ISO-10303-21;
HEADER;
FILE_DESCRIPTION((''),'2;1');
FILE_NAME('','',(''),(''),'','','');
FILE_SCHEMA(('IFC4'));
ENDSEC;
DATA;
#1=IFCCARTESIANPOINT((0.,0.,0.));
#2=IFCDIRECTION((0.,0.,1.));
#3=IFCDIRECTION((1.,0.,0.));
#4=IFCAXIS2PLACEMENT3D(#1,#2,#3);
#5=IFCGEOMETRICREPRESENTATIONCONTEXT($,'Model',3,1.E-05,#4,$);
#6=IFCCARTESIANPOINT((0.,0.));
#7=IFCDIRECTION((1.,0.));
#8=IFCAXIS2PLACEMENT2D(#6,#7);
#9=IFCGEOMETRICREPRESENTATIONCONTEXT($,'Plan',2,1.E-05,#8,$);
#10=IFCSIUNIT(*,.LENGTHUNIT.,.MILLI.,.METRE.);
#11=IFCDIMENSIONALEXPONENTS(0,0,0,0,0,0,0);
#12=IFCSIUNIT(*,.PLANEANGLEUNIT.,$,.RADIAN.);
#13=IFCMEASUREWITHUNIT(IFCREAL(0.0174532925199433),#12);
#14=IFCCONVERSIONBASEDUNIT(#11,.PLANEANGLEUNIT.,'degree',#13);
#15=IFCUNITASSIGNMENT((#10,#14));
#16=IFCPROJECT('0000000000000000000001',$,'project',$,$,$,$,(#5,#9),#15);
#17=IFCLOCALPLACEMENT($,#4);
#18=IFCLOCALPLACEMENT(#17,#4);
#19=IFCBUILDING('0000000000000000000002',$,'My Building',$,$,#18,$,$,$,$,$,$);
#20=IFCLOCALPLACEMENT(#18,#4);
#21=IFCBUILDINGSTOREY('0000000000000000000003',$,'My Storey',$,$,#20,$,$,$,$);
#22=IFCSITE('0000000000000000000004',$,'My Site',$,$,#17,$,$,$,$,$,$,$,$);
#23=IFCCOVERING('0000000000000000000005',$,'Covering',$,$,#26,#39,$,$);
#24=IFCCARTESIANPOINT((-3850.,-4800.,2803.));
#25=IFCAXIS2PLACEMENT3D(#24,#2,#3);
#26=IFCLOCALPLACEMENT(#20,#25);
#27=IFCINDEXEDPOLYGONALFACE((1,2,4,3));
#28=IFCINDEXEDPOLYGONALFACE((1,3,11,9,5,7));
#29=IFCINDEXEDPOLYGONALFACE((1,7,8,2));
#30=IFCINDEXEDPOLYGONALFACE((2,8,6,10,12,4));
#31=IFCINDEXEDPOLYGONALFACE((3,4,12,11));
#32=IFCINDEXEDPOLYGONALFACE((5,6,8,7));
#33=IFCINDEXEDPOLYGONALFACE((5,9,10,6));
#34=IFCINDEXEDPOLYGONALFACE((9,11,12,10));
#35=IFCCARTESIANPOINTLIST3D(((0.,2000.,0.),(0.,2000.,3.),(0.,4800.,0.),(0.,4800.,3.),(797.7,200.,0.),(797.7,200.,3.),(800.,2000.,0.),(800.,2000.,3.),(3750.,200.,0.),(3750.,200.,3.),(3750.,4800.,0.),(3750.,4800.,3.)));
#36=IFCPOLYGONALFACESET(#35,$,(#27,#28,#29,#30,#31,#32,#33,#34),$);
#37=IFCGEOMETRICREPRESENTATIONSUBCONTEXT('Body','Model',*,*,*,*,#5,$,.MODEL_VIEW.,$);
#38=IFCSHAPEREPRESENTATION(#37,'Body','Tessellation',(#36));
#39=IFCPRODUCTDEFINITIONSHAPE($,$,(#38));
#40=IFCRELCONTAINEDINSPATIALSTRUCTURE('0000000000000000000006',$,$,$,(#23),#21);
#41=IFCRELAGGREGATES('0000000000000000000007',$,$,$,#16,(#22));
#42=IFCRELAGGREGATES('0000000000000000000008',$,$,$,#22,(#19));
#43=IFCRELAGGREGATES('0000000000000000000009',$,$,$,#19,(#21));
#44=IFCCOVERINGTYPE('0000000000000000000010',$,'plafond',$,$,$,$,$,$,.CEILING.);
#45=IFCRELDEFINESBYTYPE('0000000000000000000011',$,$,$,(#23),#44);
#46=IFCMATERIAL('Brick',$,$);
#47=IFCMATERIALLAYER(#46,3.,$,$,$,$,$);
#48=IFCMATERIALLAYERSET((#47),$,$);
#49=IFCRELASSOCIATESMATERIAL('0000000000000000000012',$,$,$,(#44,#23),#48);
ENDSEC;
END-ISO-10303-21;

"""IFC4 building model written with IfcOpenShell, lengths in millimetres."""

from ifc_helpers import new_model, entity, si_unit, converted_unit, frame, origin_with_axes, origin_2d_with_axis, place, context, subcontext, project, spatial, line, indexed_curve, outline, extrude, material, layer, layer_set, layer_usage, type_object, element, save


model = new_model("IFC4")

# Units and contexts
model_context = context("Model", 3, precision=1e-05, world=origin_with_axes())
plan_context = context("Plan", 2, precision=1e-05, world=origin_2d_with_axis())
body_context_1 = subcontext(model_context, "Body", "Model", "MODEL_VIEW")
ifc_project = project(units=[si_unit("LENGTHUNIT", "METRE", prefix="MILLI"), converted_unit("PLANEANGLEUNIT", "degree", entity("IfcReal", 0.0174532925199433), si_unit("PLANEANGLEUNIT", "RADIAN"), dimensions=[0, 0, 0, 0, 0, 0, 0])], contexts=[model_context, plan_context])

# Site, building, storey
site_placement = place(None, origin_with_axes())
site = spatial("IfcSite", under=ifc_project, at=site_placement, Name="My Site")
building_placement = place(site_placement, origin_with_axes())
building = spatial("IfcBuilding", under=site, at=building_placement, Name="My Building")
storey_placement = place(building_placement, origin_with_axes())
storey = spatial("IfcBuildingStorey", under=building, at=storey_placement, Name="My Storey")

# Shared definitions
ifc_material = material(Name="Brick")

# Covering
ifc_layer_1 = layer(ifc_material, 3.0)
ifc_layer_set_1 = layer_set([ifc_layer_1])
ifc_layer_usage_1 = layer_usage(ifc_layer_set_1, "AXIS3", "POSITIVE", 0.0)
covering_type = type_object("IfcCoveringType", Name="plafond", PredefinedType="CEILING", material=ifc_layer_set_1)
covering_1_placement = place(storey_placement, frame((-3850.0, -4800.0, 2803.0), z_axis=(0.0, 0.0, 1.0), x_axis=(1.0, 0.0, 0.0)))
element("IfcCovering", 1, at=covering_1_placement, inside=storey, type_object=covering_type, material=ifc_layer_usage_1, Name="Covering", context=body_context_1, shape_type="SweptSolid", body=[
    extrude(outline(indexed_curve([(3750.0, 200.0), (0.0, 2000.0), (0.0, 4800.0), (3750.0, 4800.0), (797.7, 200.0), (800.0, 2000.0)], segments=[line(3, 2), line(2, 6), line(6, 5), line(5, 1), line(1, 4), line(4, 3)], self_intersect=False)), None, (0.0, 0.0, 1.0), 3.0),
])

save(model, "model.ifc")
